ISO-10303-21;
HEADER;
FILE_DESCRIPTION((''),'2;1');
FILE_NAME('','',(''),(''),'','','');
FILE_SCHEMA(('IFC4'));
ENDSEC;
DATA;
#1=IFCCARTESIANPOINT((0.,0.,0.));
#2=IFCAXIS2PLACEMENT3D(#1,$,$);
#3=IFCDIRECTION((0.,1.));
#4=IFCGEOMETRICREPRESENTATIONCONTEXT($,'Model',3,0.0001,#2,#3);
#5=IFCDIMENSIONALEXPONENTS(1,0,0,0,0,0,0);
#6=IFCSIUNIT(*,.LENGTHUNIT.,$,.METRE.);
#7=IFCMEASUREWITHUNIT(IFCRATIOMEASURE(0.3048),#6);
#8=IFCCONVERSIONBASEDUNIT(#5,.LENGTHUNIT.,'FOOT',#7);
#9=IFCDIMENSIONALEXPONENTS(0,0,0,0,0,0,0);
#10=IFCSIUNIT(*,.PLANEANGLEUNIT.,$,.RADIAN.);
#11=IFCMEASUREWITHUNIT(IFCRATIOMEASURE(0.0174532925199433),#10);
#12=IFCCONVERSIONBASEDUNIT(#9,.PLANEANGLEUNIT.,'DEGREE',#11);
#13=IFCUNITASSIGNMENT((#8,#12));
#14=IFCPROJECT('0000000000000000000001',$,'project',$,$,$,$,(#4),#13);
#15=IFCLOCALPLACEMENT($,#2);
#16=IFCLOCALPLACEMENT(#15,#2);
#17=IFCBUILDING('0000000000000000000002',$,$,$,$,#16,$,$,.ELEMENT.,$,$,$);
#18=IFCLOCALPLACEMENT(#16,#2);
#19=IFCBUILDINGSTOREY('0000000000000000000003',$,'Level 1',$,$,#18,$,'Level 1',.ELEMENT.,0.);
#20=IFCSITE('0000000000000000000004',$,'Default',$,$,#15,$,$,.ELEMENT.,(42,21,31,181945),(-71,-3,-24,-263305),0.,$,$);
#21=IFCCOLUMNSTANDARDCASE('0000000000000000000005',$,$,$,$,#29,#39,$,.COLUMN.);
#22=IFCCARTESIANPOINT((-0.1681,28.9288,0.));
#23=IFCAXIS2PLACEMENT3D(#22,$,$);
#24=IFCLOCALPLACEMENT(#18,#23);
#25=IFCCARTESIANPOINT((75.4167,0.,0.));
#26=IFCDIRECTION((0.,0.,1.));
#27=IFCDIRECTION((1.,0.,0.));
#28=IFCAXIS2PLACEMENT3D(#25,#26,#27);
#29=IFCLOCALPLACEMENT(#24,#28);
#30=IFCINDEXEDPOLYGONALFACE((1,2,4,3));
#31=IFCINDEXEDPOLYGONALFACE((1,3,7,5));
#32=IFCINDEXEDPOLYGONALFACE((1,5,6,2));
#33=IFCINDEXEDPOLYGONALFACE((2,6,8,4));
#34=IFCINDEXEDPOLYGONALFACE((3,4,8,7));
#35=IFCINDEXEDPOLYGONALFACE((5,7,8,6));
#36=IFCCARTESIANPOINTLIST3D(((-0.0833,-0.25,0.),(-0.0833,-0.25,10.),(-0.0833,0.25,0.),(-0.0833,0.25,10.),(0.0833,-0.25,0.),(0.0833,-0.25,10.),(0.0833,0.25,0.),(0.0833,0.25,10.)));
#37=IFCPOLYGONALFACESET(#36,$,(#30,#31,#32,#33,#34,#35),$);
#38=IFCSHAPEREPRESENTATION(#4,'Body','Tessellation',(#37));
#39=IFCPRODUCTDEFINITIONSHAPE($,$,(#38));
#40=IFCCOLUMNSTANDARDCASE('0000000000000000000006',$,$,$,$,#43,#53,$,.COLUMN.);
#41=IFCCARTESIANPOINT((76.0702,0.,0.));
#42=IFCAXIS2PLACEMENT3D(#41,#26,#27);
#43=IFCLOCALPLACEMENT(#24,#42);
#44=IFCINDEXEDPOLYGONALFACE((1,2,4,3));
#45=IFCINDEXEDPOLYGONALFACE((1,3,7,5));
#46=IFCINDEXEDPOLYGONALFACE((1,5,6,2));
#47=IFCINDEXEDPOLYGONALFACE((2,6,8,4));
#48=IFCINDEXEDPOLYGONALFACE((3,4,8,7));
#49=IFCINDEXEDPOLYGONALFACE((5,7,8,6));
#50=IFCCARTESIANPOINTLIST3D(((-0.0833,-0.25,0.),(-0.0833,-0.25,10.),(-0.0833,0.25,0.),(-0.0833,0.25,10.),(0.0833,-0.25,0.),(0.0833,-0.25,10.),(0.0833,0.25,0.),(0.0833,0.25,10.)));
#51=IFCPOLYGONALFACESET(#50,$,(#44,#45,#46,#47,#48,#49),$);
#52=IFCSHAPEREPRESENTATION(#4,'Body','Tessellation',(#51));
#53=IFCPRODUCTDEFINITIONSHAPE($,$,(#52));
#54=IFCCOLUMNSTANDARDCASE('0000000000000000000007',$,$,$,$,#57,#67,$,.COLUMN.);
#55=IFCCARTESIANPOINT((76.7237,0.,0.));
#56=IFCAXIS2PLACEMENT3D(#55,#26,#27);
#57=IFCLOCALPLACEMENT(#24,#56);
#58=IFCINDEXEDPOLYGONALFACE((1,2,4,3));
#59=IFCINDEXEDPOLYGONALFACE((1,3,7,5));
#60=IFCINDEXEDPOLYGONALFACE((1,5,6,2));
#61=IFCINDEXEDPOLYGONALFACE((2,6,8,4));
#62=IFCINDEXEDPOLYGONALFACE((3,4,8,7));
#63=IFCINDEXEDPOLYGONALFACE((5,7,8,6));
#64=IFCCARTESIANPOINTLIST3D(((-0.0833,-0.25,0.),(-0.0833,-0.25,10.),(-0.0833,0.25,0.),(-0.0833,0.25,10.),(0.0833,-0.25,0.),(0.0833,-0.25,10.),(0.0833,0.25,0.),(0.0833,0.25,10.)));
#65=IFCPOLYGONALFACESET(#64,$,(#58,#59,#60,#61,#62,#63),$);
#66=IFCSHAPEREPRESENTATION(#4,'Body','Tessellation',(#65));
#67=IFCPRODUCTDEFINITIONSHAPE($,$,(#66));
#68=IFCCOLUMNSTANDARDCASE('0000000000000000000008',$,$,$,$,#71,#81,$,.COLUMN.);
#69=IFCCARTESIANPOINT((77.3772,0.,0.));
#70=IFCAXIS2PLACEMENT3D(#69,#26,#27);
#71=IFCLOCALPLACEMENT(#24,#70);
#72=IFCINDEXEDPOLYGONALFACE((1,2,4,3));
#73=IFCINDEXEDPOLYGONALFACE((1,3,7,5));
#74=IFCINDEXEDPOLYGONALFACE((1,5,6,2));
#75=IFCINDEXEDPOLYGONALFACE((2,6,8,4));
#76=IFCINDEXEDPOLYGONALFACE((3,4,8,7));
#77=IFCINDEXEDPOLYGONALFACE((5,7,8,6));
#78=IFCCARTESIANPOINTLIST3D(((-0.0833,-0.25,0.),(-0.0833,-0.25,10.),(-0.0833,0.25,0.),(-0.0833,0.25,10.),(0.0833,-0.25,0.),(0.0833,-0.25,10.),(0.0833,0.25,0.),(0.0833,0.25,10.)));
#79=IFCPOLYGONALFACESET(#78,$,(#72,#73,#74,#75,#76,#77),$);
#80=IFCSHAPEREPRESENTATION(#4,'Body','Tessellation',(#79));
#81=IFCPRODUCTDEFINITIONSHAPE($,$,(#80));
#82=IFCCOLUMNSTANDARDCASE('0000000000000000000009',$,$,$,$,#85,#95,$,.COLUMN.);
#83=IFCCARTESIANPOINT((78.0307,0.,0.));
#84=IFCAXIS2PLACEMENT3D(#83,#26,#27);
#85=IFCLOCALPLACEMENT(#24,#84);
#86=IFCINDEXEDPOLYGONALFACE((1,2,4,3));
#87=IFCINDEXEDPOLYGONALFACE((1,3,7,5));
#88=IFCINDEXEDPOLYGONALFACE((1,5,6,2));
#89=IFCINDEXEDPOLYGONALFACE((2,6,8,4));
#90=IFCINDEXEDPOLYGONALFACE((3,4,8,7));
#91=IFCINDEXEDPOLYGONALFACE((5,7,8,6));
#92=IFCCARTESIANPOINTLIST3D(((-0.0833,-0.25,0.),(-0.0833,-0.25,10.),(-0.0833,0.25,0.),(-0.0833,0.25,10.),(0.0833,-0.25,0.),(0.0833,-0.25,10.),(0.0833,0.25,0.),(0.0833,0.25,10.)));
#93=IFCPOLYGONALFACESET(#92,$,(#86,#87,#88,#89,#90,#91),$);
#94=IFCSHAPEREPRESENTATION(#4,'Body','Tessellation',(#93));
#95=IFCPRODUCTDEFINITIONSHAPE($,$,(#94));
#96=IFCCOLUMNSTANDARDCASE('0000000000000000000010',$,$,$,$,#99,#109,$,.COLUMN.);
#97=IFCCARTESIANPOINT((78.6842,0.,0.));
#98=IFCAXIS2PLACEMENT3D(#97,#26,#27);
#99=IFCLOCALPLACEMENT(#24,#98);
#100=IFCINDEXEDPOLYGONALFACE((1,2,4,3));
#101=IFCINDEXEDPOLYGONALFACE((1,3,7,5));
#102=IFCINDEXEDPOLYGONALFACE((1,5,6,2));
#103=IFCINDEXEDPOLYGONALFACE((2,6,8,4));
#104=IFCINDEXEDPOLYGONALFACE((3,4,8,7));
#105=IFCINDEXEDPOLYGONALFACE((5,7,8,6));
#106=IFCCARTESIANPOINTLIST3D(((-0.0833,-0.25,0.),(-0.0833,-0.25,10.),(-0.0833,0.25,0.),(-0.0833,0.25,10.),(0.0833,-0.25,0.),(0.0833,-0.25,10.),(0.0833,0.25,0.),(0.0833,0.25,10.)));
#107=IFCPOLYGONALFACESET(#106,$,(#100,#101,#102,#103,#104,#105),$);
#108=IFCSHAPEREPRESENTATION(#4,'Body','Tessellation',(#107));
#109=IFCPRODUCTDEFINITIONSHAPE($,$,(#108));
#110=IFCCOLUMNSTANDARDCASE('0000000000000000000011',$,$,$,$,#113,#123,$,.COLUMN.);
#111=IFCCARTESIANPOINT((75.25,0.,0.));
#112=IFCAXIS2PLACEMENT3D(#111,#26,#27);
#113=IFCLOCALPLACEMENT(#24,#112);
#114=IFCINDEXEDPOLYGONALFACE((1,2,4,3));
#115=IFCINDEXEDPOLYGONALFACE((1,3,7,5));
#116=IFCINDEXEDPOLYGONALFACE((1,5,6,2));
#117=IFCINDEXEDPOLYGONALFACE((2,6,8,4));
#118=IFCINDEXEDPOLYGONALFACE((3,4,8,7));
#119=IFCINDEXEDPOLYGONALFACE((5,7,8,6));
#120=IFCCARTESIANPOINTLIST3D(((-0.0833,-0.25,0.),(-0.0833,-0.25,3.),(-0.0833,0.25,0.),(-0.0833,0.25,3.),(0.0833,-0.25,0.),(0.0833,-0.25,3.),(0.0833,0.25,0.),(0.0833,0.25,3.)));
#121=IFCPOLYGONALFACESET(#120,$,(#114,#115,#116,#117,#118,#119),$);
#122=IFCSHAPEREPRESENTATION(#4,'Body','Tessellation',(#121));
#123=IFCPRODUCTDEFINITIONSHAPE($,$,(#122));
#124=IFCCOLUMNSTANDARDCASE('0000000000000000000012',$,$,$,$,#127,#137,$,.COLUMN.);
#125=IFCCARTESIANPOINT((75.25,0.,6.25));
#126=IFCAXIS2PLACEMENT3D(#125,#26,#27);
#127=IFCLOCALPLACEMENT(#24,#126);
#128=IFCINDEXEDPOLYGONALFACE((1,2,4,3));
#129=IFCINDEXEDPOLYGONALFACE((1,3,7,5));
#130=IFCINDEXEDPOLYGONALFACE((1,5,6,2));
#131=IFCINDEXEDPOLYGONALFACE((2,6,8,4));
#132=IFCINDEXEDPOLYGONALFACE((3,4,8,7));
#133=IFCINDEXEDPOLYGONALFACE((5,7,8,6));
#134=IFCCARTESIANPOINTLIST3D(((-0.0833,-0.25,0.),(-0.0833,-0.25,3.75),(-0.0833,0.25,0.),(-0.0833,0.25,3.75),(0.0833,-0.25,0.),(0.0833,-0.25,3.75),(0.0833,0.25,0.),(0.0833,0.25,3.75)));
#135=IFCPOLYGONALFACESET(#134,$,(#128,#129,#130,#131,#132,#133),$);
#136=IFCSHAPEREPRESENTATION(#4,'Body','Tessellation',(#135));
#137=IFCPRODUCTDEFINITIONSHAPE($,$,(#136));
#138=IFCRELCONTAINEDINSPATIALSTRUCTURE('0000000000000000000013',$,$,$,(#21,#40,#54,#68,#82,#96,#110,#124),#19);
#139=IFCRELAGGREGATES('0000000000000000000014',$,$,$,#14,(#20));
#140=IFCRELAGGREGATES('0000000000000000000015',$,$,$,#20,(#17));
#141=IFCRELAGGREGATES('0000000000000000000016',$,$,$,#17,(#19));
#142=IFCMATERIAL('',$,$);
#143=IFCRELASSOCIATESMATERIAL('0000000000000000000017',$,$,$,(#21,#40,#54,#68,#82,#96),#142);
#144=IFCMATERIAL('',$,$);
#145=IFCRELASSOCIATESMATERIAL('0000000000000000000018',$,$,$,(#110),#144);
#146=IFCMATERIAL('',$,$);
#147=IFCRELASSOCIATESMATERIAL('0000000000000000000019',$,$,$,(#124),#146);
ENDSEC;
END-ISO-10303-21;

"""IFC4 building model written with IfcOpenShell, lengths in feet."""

from ifc_helpers import new_model, entity, si_unit, converted_unit, direction, frame, origin, place, context, project, spatial, rectangle, extrude, material, element, save


model = new_model("IFC4")

# Units and contexts
model_context = context("Model", 3, precision=0.0001, world=origin(), true_north=direction((0.0, 1.0)))
ifc_project = project(units=[converted_unit("LENGTHUNIT", "FOOT", entity("IfcRatioMeasure", 0.3048), si_unit("LENGTHUNIT", "METRE"), dimensions=[1, 0, 0, 0, 0, 0, 0]), converted_unit("PLANEANGLEUNIT", "DEGREE", entity("IfcRatioMeasure", 0.0174532925199433), si_unit("PLANEANGLEUNIT", "RADIAN"), dimensions=[0, 0, 0, 0, 0, 0, 0])], contexts=[model_context])

# Site, building, storey
site_placement = place(None, origin())
site = spatial("IfcSite", under=ifc_project, at=site_placement, Name="Default", CompositionType="ELEMENT", RefLatitude=(42, 21, 31, 181945), RefLongitude=(-71, -3, -24, -263305), RefElevation=0.0)
building_placement = place(site_placement, origin())
building = spatial("IfcBuilding", under=site, at=building_placement, CompositionType="ELEMENT")
storey_placement = place(building_placement, origin())
storey = spatial("IfcBuildingStorey", under=building, at=storey_placement, Name="Level 1", LongName="Level 1", CompositionType="ELEMENT", Elevation=0.0)

# Columns
ifc_material_1 = material(Name="")
placement = place(storey_placement, frame((-0.1681, 28.9288, 0.0)))
for number, where, z_axis, x_axis in (
    (1, (75.4167, 0.0, 0.0), (0.0, 0.0, 1.0), (1.0, 0.0, 0.0)),
    (2, (76.0702, 0.0, 0.0), (0.0, 0.0, 1.0), (1.0, 0.0, 0.0)),
    (3, (76.7237, 0.0, 0.0), (0.0, 0.0, 1.0), (1.0, 0.0, 0.0)),
    (4, (77.3772, 0.0, 0.0), (0.0, 0.0, 1.0), (1.0, 0.0, 0.0)),
    (5, (78.0307, 0.0, 0.0), (0.0, 0.0, 1.0), (1.0, 0.0, 0.0)),
    (6, (78.6842, 0.0, 0.0), (0.0, 0.0, 1.0), (1.0, 0.0, 0.0)),
):
    element("IfcColumnStandardCase", number, at=place(placement, frame(where, z_axis=z_axis, x_axis=x_axis)), inside=storey, material=ifc_material_1, PredefinedType="COLUMN", context=model_context, shape_type="SweptSolid", body=[
        extrude(rectangle(XDim=0.1667, YDim=0.5), origin(), (0.0, 0.0, 1.0), 10.0),
    ])
ifc_material_2 = material(Name="")
for number, where, z_axis, x_axis in (
    (7, (75.25, 0.0, 0.0), (0.0, 0.0, 1.0), (1.0, 0.0, 0.0)),
):
    element("IfcColumnStandardCase", number, at=place(placement, frame(where, z_axis=z_axis, x_axis=x_axis)), inside=storey, material=ifc_material_2, PredefinedType="COLUMN", context=model_context, shape_type="SweptSolid", body=[
        extrude(rectangle(XDim=0.1667, YDim=0.5), origin(), (0.0, 0.0, 1.0), 3.0),
    ])
ifc_material_3 = material(Name="")
for number, where, z_axis, x_axis in (
    (8, (75.25, 0.0, 6.25), (0.0, 0.0, 1.0), (1.0, 0.0, 0.0)),
):
    element("IfcColumnStandardCase", number, at=place(placement, frame(where, z_axis=z_axis, x_axis=x_axis)), inside=storey, material=ifc_material_3, PredefinedType="COLUMN", context=model_context, shape_type="SweptSolid", body=[
        extrude(rectangle(XDim=0.1667, YDim=0.5), origin(), (0.0, 0.0, 1.0), 3.75),
    ])

save(model, "model.ifc")
